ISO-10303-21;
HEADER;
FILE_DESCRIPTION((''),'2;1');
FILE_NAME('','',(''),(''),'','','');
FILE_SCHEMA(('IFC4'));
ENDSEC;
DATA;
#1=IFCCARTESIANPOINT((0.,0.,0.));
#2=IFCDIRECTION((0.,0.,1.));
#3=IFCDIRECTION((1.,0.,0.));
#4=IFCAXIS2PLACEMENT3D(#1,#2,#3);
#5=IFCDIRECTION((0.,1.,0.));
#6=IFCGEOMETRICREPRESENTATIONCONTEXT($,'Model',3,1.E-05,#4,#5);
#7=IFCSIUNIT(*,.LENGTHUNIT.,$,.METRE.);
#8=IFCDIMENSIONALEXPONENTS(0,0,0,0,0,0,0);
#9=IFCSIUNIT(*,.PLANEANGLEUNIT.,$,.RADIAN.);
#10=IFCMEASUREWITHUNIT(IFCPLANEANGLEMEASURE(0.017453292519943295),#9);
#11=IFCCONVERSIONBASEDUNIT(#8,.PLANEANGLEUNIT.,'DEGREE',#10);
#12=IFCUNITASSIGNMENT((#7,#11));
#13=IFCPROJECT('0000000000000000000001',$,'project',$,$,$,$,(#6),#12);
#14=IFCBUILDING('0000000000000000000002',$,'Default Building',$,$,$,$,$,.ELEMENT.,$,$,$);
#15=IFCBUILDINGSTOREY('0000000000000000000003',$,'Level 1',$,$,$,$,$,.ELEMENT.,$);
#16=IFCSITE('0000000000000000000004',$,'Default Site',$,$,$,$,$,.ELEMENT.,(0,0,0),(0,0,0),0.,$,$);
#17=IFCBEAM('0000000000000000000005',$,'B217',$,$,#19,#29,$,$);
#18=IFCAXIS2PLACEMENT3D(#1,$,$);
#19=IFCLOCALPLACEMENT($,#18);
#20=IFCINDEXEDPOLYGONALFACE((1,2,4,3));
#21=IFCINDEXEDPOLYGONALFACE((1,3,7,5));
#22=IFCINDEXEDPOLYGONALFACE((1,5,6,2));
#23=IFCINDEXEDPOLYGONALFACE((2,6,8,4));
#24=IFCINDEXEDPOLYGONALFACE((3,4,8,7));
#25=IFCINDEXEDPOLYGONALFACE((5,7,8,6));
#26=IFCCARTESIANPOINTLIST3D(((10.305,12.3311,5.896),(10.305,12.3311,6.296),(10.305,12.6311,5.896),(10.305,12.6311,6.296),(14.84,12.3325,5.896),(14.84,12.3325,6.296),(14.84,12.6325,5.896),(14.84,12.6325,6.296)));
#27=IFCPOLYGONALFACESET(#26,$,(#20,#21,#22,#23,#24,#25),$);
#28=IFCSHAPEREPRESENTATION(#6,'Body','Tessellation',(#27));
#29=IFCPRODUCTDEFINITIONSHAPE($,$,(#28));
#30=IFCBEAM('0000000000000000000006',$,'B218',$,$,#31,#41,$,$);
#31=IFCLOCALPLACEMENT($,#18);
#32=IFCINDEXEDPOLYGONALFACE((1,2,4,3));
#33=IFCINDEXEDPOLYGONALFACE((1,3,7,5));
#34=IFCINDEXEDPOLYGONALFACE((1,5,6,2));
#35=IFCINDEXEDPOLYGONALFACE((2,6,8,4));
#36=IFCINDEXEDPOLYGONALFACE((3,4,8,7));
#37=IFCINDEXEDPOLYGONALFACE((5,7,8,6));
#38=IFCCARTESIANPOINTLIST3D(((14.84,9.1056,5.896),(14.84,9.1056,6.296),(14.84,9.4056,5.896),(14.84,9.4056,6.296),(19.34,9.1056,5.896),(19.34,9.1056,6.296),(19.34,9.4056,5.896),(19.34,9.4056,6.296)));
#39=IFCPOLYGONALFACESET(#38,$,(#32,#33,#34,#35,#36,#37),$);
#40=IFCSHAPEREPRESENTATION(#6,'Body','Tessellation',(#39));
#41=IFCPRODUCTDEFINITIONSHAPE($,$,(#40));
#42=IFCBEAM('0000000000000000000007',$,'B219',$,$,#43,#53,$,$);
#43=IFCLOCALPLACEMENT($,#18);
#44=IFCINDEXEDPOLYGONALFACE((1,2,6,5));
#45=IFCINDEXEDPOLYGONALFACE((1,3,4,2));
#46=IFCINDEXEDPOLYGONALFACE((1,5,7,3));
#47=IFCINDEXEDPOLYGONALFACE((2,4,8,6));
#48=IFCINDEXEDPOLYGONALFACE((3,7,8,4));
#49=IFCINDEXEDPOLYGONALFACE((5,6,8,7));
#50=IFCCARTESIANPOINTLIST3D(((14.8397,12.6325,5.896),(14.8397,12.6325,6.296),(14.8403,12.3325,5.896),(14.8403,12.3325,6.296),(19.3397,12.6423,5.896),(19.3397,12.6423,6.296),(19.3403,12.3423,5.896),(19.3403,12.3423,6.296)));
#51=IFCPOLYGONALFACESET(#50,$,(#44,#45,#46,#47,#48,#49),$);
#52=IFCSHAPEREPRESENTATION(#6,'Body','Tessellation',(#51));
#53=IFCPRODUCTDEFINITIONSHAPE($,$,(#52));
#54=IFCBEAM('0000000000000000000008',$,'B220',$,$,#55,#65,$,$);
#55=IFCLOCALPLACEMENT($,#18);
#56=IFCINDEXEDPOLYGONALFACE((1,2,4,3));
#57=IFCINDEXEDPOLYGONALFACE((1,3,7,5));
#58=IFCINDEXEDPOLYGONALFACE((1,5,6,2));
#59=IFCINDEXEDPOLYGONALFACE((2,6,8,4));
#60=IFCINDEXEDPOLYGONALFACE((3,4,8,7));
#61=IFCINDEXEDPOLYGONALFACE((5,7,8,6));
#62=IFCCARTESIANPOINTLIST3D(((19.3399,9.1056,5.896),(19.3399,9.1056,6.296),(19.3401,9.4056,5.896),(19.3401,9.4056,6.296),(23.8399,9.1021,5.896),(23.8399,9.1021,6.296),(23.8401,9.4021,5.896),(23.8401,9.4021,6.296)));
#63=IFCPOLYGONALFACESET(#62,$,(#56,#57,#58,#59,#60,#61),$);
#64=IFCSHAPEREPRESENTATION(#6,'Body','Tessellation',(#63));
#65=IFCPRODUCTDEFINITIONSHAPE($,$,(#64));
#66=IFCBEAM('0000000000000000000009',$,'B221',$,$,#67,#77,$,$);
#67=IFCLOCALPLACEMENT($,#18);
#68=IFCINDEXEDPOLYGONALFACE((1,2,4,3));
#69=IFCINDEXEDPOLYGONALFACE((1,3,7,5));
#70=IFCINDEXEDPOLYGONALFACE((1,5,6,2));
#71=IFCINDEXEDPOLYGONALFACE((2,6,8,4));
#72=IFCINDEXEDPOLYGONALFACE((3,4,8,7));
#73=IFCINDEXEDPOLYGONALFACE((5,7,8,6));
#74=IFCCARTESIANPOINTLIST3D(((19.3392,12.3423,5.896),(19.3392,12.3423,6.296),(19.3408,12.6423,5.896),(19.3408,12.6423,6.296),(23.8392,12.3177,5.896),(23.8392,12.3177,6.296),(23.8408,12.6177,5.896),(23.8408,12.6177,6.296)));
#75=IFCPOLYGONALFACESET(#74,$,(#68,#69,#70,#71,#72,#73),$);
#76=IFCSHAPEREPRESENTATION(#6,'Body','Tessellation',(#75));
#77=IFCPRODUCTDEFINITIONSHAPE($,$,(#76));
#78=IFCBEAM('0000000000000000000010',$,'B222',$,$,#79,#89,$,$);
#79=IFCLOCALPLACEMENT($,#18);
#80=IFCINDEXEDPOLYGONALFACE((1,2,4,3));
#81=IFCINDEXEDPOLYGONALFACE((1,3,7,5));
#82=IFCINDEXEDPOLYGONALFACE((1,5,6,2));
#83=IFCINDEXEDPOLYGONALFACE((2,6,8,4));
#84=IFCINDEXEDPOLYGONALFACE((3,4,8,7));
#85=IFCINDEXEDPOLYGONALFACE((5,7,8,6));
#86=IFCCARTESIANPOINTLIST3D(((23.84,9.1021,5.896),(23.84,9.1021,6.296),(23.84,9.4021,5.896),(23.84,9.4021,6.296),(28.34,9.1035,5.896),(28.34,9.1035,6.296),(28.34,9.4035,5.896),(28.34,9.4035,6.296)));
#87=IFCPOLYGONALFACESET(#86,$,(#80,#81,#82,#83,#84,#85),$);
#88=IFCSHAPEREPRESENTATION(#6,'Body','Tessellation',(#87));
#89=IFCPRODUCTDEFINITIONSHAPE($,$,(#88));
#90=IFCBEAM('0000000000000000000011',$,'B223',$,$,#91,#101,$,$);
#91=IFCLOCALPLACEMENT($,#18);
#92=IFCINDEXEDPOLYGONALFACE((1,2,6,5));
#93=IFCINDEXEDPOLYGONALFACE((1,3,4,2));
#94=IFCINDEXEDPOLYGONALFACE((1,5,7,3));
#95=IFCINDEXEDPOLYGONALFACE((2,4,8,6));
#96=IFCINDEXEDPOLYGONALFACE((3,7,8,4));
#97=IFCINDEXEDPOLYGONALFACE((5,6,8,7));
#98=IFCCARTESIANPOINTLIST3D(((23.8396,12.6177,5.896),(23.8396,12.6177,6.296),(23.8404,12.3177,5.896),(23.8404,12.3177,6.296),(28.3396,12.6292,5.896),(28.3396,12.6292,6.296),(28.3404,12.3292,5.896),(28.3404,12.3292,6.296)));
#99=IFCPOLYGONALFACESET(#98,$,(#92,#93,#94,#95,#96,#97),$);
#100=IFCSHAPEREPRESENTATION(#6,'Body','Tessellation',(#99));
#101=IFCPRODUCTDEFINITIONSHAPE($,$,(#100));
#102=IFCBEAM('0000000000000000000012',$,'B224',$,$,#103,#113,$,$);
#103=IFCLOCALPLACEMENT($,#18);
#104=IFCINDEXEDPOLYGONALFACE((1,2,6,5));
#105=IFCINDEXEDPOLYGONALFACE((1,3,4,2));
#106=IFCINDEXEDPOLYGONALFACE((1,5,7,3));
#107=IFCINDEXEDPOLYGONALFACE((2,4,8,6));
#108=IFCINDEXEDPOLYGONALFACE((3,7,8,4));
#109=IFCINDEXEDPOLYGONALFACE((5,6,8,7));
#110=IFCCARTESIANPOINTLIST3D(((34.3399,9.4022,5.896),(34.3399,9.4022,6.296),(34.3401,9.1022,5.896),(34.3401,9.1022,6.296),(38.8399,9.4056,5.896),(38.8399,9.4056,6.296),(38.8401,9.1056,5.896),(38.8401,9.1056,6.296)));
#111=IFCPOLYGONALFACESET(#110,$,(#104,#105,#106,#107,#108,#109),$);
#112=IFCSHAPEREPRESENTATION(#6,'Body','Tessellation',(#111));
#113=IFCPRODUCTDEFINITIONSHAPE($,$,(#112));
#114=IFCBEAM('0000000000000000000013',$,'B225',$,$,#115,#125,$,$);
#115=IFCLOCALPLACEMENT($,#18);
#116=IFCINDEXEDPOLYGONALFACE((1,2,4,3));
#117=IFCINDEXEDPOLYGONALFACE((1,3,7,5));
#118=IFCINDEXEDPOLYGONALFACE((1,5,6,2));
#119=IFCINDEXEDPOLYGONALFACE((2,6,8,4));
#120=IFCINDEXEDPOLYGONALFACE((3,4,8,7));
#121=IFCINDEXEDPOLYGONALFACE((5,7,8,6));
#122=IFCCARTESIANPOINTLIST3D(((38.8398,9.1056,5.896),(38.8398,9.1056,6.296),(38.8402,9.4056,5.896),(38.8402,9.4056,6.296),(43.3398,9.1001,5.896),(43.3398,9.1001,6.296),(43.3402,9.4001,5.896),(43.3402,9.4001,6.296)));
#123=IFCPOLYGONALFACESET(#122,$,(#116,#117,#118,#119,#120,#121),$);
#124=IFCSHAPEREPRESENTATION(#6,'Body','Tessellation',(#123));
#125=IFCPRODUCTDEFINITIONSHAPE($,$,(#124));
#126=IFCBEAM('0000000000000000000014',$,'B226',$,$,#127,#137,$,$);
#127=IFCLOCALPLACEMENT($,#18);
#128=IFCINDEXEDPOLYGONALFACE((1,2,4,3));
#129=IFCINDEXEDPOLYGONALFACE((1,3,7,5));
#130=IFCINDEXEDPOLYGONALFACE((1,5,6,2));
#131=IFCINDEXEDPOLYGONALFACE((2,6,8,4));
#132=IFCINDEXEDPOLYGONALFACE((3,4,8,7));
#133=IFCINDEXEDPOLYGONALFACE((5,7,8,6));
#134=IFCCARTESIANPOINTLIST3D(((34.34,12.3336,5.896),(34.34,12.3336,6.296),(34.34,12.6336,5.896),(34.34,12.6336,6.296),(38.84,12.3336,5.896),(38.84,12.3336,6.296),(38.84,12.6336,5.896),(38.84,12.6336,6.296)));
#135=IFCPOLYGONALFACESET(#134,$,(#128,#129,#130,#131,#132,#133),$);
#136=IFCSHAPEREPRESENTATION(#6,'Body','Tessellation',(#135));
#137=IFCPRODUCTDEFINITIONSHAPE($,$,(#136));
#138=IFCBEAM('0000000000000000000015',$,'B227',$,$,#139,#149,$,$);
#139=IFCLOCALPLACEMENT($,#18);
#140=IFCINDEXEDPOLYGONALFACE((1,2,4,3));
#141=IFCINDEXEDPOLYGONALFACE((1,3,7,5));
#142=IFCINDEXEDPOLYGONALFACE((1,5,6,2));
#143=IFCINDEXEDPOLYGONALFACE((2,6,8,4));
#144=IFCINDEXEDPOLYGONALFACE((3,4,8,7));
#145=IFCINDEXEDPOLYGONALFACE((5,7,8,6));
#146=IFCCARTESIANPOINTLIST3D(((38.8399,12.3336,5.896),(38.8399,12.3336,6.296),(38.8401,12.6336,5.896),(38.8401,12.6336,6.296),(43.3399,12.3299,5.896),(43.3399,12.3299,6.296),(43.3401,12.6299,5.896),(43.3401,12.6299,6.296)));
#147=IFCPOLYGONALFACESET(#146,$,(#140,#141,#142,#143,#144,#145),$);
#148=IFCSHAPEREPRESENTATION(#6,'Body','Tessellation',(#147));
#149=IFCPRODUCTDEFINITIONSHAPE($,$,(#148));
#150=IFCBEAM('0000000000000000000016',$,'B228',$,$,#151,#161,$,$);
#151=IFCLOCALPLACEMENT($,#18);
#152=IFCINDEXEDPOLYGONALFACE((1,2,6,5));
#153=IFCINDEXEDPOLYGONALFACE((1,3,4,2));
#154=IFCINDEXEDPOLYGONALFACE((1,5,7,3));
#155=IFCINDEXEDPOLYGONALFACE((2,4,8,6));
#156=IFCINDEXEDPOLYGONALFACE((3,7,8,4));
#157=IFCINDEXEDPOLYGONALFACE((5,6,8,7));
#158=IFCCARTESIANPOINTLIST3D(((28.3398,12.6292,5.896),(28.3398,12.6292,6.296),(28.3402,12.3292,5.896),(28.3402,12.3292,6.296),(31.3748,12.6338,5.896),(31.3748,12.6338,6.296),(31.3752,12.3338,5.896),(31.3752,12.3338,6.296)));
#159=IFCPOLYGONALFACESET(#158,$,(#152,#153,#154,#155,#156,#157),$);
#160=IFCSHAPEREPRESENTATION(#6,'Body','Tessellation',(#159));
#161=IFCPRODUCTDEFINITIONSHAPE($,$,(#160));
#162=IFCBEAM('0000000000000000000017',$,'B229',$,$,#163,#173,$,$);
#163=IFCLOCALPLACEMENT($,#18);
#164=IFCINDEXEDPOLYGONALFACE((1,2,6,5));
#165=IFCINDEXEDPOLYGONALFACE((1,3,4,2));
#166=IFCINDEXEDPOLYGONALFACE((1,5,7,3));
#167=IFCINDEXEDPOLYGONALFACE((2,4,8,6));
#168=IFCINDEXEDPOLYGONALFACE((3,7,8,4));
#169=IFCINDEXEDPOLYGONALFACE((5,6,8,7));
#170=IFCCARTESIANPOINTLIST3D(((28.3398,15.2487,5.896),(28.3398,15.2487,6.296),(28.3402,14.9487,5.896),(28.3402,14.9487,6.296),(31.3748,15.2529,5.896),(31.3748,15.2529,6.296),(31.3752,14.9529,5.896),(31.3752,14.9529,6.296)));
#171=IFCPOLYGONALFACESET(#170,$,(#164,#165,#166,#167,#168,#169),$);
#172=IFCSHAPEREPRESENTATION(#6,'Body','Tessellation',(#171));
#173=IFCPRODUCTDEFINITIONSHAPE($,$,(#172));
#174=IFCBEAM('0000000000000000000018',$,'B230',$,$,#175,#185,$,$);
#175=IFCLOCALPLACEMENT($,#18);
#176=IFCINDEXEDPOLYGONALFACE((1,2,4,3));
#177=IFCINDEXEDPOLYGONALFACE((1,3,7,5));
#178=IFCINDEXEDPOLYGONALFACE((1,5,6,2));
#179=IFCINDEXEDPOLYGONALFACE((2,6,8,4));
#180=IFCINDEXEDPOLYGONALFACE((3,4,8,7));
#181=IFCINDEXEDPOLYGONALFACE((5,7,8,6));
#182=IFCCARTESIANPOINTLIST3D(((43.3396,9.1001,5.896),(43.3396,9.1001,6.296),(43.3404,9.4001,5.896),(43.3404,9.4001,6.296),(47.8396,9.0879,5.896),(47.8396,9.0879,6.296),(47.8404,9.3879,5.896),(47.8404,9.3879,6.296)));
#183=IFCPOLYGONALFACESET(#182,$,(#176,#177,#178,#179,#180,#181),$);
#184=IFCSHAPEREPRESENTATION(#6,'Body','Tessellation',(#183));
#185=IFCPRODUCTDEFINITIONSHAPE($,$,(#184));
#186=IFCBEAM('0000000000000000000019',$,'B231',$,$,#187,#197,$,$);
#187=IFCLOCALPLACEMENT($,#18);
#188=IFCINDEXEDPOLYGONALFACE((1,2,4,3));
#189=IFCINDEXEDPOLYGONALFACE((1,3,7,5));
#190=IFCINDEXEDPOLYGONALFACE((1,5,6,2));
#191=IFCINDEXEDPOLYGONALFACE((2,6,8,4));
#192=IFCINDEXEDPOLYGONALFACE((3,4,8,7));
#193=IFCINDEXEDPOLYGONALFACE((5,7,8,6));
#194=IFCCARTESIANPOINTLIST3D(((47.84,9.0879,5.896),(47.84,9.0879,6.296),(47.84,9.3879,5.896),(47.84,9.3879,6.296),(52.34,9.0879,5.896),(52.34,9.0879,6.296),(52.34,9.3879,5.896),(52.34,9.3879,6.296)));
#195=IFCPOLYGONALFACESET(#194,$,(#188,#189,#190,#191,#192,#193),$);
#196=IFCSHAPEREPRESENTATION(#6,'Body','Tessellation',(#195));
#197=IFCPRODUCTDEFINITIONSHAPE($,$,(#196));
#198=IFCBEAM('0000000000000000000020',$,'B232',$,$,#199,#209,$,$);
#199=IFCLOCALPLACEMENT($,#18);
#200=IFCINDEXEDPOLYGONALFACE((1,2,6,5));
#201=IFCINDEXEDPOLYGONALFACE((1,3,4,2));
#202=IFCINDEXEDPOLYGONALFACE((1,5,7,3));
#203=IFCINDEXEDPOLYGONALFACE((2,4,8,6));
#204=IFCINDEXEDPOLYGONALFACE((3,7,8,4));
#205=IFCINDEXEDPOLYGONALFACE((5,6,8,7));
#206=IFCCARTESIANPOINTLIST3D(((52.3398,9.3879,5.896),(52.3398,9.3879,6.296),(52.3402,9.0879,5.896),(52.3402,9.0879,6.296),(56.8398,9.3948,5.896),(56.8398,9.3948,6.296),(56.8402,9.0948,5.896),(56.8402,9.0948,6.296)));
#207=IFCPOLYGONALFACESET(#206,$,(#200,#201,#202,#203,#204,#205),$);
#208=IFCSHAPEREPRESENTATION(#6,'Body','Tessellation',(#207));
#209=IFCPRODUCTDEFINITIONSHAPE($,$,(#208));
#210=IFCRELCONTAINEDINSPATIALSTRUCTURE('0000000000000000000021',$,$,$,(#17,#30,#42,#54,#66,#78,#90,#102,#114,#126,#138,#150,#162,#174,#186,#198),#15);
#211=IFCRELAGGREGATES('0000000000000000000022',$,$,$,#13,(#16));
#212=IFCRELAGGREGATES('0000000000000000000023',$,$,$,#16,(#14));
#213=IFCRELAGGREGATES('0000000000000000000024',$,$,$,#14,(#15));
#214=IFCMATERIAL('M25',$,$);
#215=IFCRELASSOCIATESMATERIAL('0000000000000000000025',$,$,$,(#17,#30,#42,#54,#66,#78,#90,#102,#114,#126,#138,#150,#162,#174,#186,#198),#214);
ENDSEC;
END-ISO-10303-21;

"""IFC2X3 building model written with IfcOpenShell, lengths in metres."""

from ifc_helpers import new_model, entity, si_unit, converted_unit, direction, frame, frame_2d, origin_with_axes, place, context, project, spatial, rectangle, extrude, material, element, save


model = new_model("IFC2X3")

# Units and contexts
model_context = context("Model", 3, precision=1e-05, world=origin_with_axes(), true_north=direction((0.0, 1.0, 0.0)))
ifc_project = project(units=[si_unit("LENGTHUNIT", "METRE"), converted_unit("PLANEANGLEUNIT", "DEGREE", entity("IfcPlaneAngleMeasure", 0.017453292519943295), si_unit("PLANEANGLEUNIT", "RADIAN"), dimensions=[0, 0, 0, 0, 0, 0, 0])], contexts=[model_context])

# Site, building, storey
site = spatial("IfcSite", under=ifc_project, Name="Default Site", CompositionType="ELEMENT", RefLatitude=(0, 0, 0), RefLongitude=(0, 0, 0), RefElevation=0.0)
building = spatial("IfcBuilding", under=site, Name="Default Building", CompositionType="ELEMENT")
storey = spatial("IfcBuildingStorey", under=building, Name="Level 1", CompositionType="ELEMENT")

# Beams
ifc_material = material(Name="M25")
placement = place(None, origin_with_axes())
element("IfcBeam", 1, at=placement, inside=storey, material=ifc_material, Name="B217", context=model_context, shape_type="SweptSolid", body=[
    extrude(rectangle(XDim=0.3, YDim=0.4, at=frame_2d((0.0, 0.0), x_axis=(0.0, 1.0, 0.0))), frame((10.305, 12.4811, 6.096), z_axis=(1.0, 0.000301, 0.0), x_axis=(0.0, 0.0, -1.0)), (0.0, 0.0, 1.0), 4.535),
])
element("IfcBeam", 2, at=placement, inside=storey, material=ifc_material, Name="B218", context=model_context, shape_type="SweptSolid", body=[
    extrude(rectangle(XDim=0.3, YDim=0.4, at=frame_2d((0.0, 0.0), x_axis=(0.0, 1.0, 0.0))), frame((14.84, 9.2556, 6.096), z_axis=(1.0, 0.000013, 0.0), x_axis=(0.0, 0.0, -1.0)), (0.0, 0.0, 1.0), 4.5),
])
element("IfcBeam", 3, at=placement, inside=storey, material=ifc_material, Name="B219", context=model_context, shape_type="SweptSolid", body=[
    extrude(rectangle(XDim=0.3, YDim=0.4, at=frame_2d((0.0, 0.0), x_axis=(0.0, 1.0, 0.0))), frame((14.84, 12.4825, 6.096), z_axis=(0.999998, 0.002176, 0.0), x_axis=(0.0, 0.0, -1.0)), (0.0, 0.0, 1.0), 4.5),
])
element("IfcBeam", 4, at=placement, inside=storey, material=ifc_material, Name="B220", context=model_context, shape_type="SweptSolid", body=[
    extrude(rectangle(XDim=0.3, YDim=0.4, at=frame_2d((0.0, 0.0), x_axis=(0.0, 1.0, 0.0))), frame((19.34, 9.2556, 6.096), z_axis=(1.0, -0.000779, 0.0), x_axis=(0.0, 0.0, -1.0)), (0.0, 0.0, 1.0), 4.5),
])
element("IfcBeam", 5, at=placement, inside=storey, material=ifc_material, Name="B221", context=model_context, shape_type="SweptSolid", body=[
    extrude(rectangle(XDim=0.3, YDim=0.4, at=frame_2d((0.0, 0.0), x_axis=(0.0, 1.0, 0.0))), frame((19.34, 12.4923, 6.096), z_axis=(0.999985, -0.005463, 0.0), x_axis=(0.0, 0.0, -1.0)), (0.0, 0.0, 1.0), 4.5001),
])
element("IfcBeam", 6, at=placement, inside=storey, material=ifc_material, Name="B222", context=model_context, shape_type="SweptSolid", body=[
    extrude(rectangle(XDim=0.3, YDim=0.4, at=frame_2d((0.0, 0.0), x_axis=(0.0, 1.0, 0.0))), frame((23.84, 9.2521, 6.096), z_axis=(1.0, 0.000307, 0.0), x_axis=(0.0, 0.0, -1.0)), (0.0, 0.0, 1.0), 4.5),
])
element("IfcBeam", 7, at=placement, inside=storey, material=ifc_material, Name="B223", context=model_context, shape_type="SweptSolid", body=[
    extrude(rectangle(XDim=0.3, YDim=0.4, at=frame_2d((0.0, 0.0), x_axis=(0.0, 1.0, 0.0))), frame((23.84, 12.4677, 6.096), z_axis=(0.999997, 0.002551, 0.0), x_axis=(0.0, 0.0, -1.0)), (0.0, 0.0, 1.0), 4.5),
])
element("IfcBeam", 8, at=placement, inside=storey, material=ifc_material, Name="B224", context=model_context, shape_type="SweptSolid", body=[
    extrude(rectangle(XDim=0.3, YDim=0.4, at=frame_2d((0.0, 0.0), x_axis=(0.0, 1.0, 0.0))), frame((34.34, 9.2522, 6.096), z_axis=(1.0, 0.000748, 0.0), x_axis=(0.0, 0.0, -1.0)), (0.0, 0.0, 1.0), 4.5),
])
element("IfcBeam", 9, at=placement, inside=storey, material=ifc_material, Name="B225", context=model_context, shape_type="SweptSolid", body=[
    extrude(rectangle(XDim=0.3, YDim=0.4, at=frame_2d((0.0, 0.0), x_axis=(0.0, 1.0, 0.0))), frame((38.84, 9.2556, 6.096), z_axis=(0.999999, -0.001227, 0.0), x_axis=(0.0, 0.0, -1.0)), (0.0, 0.0, 1.0), 4.5),
])
element("IfcBeam", 10, at=placement, inside=storey, material=ifc_material, Name="B226", context=model_context, shape_type="SweptSolid", body=[
    extrude(rectangle(XDim=0.3, YDim=0.4, at=frame_2d((0.0, 0.0), x_axis=(0.0, 1.0, 0.0))), frame((34.34, 12.4836, 6.096), z_axis=(1.0, -0.000008, 0.0), x_axis=(0.0, 0.0, -1.0)), (0.0, 0.0, 1.0), 4.5),
])
element("IfcBeam", 11, at=placement, inside=storey, material=ifc_material, Name="B227", context=model_context, shape_type="SweptSolid", body=[
    extrude(rectangle(XDim=0.3, YDim=0.4, at=frame_2d((0.0, 0.0), x_axis=(0.0, 1.0, 0.0))), frame((38.84, 12.4836, 6.096), z_axis=(1.0, -0.000826, 0.0), x_axis=(0.0, 0.0, -1.0)), (0.0, 0.0, 1.0), 4.5),
])
element("IfcBeam", 12, at=placement, inside=storey, material=ifc_material, Name="B228", context=model_context, shape_type="SweptSolid", body=[
    extrude(rectangle(XDim=0.3, YDim=0.4, at=frame_2d((0.0, 0.0), x_axis=(0.0, 1.0, 0.0))), frame((28.34, 12.4792, 6.096), z_axis=(0.999999, 0.001542, 0.0), x_axis=(0.0, 0.0, -1.0)), (0.0, 0.0, 1.0), 3.035),
])
element("IfcBeam", 13, at=placement, inside=storey, material=ifc_material, Name="B229", context=model_context, shape_type="SweptSolid", body=[
    extrude(rectangle(XDim=0.3, YDim=0.4, at=frame_2d((0.0, 0.0), x_axis=(0.0, 1.0, 0.0))), frame((31.375, 15.1029, 6.096), z_axis=(-0.999999, -0.001391, 0.0), x_axis=(0.0, 0.0, -1.0)), (0.0, 0.0, 1.0), 3.035),
])
element("IfcBeam", 14, at=placement, inside=storey, material=ifc_material, Name="B230", context=model_context, shape_type="SweptSolid", body=[
    extrude(rectangle(XDim=0.3, YDim=0.4, at=frame_2d((0.0, 0.0), x_axis=(0.0, 1.0, 0.0))), frame((43.34, 9.2501, 6.096), z_axis=(0.999996, -0.002702, 0.0), x_axis=(0.0, 0.0, -1.0)), (0.0, 0.0, 1.0), 4.5),
])
element("IfcBeam", 15, at=placement, inside=storey, material=ifc_material, Name="B231", context=model_context, shape_type="SweptSolid", body=[
    extrude(rectangle(XDim=0.3, YDim=0.4, at=frame_2d((0.0, 0.0), x_axis=(0.0, 1.0, 0.0))), frame((47.84, 9.2379, 6.096), z_axis=(1.0, 0.0, 0.0), x_axis=(0.0, 0.0, -1.0)), (0.0, 0.0, 1.0), 4.5),
])
element("IfcBeam", 16, at=placement, inside=storey, material=ifc_material, Name="B232", context=model_context, shape_type="SweptSolid", body=[
    extrude(rectangle(XDim=0.3, YDim=0.4, at=frame_2d((0.0, 0.0), x_axis=(0.0, 1.0, 0.0))), frame((52.34, 9.2379, 6.096), z_axis=(0.999999, 0.001537, 0.0), x_axis=(0.0, 0.0, -1.0)), (0.0, 0.0, 1.0), 4.5),
])

save(model, "model.ifc")
